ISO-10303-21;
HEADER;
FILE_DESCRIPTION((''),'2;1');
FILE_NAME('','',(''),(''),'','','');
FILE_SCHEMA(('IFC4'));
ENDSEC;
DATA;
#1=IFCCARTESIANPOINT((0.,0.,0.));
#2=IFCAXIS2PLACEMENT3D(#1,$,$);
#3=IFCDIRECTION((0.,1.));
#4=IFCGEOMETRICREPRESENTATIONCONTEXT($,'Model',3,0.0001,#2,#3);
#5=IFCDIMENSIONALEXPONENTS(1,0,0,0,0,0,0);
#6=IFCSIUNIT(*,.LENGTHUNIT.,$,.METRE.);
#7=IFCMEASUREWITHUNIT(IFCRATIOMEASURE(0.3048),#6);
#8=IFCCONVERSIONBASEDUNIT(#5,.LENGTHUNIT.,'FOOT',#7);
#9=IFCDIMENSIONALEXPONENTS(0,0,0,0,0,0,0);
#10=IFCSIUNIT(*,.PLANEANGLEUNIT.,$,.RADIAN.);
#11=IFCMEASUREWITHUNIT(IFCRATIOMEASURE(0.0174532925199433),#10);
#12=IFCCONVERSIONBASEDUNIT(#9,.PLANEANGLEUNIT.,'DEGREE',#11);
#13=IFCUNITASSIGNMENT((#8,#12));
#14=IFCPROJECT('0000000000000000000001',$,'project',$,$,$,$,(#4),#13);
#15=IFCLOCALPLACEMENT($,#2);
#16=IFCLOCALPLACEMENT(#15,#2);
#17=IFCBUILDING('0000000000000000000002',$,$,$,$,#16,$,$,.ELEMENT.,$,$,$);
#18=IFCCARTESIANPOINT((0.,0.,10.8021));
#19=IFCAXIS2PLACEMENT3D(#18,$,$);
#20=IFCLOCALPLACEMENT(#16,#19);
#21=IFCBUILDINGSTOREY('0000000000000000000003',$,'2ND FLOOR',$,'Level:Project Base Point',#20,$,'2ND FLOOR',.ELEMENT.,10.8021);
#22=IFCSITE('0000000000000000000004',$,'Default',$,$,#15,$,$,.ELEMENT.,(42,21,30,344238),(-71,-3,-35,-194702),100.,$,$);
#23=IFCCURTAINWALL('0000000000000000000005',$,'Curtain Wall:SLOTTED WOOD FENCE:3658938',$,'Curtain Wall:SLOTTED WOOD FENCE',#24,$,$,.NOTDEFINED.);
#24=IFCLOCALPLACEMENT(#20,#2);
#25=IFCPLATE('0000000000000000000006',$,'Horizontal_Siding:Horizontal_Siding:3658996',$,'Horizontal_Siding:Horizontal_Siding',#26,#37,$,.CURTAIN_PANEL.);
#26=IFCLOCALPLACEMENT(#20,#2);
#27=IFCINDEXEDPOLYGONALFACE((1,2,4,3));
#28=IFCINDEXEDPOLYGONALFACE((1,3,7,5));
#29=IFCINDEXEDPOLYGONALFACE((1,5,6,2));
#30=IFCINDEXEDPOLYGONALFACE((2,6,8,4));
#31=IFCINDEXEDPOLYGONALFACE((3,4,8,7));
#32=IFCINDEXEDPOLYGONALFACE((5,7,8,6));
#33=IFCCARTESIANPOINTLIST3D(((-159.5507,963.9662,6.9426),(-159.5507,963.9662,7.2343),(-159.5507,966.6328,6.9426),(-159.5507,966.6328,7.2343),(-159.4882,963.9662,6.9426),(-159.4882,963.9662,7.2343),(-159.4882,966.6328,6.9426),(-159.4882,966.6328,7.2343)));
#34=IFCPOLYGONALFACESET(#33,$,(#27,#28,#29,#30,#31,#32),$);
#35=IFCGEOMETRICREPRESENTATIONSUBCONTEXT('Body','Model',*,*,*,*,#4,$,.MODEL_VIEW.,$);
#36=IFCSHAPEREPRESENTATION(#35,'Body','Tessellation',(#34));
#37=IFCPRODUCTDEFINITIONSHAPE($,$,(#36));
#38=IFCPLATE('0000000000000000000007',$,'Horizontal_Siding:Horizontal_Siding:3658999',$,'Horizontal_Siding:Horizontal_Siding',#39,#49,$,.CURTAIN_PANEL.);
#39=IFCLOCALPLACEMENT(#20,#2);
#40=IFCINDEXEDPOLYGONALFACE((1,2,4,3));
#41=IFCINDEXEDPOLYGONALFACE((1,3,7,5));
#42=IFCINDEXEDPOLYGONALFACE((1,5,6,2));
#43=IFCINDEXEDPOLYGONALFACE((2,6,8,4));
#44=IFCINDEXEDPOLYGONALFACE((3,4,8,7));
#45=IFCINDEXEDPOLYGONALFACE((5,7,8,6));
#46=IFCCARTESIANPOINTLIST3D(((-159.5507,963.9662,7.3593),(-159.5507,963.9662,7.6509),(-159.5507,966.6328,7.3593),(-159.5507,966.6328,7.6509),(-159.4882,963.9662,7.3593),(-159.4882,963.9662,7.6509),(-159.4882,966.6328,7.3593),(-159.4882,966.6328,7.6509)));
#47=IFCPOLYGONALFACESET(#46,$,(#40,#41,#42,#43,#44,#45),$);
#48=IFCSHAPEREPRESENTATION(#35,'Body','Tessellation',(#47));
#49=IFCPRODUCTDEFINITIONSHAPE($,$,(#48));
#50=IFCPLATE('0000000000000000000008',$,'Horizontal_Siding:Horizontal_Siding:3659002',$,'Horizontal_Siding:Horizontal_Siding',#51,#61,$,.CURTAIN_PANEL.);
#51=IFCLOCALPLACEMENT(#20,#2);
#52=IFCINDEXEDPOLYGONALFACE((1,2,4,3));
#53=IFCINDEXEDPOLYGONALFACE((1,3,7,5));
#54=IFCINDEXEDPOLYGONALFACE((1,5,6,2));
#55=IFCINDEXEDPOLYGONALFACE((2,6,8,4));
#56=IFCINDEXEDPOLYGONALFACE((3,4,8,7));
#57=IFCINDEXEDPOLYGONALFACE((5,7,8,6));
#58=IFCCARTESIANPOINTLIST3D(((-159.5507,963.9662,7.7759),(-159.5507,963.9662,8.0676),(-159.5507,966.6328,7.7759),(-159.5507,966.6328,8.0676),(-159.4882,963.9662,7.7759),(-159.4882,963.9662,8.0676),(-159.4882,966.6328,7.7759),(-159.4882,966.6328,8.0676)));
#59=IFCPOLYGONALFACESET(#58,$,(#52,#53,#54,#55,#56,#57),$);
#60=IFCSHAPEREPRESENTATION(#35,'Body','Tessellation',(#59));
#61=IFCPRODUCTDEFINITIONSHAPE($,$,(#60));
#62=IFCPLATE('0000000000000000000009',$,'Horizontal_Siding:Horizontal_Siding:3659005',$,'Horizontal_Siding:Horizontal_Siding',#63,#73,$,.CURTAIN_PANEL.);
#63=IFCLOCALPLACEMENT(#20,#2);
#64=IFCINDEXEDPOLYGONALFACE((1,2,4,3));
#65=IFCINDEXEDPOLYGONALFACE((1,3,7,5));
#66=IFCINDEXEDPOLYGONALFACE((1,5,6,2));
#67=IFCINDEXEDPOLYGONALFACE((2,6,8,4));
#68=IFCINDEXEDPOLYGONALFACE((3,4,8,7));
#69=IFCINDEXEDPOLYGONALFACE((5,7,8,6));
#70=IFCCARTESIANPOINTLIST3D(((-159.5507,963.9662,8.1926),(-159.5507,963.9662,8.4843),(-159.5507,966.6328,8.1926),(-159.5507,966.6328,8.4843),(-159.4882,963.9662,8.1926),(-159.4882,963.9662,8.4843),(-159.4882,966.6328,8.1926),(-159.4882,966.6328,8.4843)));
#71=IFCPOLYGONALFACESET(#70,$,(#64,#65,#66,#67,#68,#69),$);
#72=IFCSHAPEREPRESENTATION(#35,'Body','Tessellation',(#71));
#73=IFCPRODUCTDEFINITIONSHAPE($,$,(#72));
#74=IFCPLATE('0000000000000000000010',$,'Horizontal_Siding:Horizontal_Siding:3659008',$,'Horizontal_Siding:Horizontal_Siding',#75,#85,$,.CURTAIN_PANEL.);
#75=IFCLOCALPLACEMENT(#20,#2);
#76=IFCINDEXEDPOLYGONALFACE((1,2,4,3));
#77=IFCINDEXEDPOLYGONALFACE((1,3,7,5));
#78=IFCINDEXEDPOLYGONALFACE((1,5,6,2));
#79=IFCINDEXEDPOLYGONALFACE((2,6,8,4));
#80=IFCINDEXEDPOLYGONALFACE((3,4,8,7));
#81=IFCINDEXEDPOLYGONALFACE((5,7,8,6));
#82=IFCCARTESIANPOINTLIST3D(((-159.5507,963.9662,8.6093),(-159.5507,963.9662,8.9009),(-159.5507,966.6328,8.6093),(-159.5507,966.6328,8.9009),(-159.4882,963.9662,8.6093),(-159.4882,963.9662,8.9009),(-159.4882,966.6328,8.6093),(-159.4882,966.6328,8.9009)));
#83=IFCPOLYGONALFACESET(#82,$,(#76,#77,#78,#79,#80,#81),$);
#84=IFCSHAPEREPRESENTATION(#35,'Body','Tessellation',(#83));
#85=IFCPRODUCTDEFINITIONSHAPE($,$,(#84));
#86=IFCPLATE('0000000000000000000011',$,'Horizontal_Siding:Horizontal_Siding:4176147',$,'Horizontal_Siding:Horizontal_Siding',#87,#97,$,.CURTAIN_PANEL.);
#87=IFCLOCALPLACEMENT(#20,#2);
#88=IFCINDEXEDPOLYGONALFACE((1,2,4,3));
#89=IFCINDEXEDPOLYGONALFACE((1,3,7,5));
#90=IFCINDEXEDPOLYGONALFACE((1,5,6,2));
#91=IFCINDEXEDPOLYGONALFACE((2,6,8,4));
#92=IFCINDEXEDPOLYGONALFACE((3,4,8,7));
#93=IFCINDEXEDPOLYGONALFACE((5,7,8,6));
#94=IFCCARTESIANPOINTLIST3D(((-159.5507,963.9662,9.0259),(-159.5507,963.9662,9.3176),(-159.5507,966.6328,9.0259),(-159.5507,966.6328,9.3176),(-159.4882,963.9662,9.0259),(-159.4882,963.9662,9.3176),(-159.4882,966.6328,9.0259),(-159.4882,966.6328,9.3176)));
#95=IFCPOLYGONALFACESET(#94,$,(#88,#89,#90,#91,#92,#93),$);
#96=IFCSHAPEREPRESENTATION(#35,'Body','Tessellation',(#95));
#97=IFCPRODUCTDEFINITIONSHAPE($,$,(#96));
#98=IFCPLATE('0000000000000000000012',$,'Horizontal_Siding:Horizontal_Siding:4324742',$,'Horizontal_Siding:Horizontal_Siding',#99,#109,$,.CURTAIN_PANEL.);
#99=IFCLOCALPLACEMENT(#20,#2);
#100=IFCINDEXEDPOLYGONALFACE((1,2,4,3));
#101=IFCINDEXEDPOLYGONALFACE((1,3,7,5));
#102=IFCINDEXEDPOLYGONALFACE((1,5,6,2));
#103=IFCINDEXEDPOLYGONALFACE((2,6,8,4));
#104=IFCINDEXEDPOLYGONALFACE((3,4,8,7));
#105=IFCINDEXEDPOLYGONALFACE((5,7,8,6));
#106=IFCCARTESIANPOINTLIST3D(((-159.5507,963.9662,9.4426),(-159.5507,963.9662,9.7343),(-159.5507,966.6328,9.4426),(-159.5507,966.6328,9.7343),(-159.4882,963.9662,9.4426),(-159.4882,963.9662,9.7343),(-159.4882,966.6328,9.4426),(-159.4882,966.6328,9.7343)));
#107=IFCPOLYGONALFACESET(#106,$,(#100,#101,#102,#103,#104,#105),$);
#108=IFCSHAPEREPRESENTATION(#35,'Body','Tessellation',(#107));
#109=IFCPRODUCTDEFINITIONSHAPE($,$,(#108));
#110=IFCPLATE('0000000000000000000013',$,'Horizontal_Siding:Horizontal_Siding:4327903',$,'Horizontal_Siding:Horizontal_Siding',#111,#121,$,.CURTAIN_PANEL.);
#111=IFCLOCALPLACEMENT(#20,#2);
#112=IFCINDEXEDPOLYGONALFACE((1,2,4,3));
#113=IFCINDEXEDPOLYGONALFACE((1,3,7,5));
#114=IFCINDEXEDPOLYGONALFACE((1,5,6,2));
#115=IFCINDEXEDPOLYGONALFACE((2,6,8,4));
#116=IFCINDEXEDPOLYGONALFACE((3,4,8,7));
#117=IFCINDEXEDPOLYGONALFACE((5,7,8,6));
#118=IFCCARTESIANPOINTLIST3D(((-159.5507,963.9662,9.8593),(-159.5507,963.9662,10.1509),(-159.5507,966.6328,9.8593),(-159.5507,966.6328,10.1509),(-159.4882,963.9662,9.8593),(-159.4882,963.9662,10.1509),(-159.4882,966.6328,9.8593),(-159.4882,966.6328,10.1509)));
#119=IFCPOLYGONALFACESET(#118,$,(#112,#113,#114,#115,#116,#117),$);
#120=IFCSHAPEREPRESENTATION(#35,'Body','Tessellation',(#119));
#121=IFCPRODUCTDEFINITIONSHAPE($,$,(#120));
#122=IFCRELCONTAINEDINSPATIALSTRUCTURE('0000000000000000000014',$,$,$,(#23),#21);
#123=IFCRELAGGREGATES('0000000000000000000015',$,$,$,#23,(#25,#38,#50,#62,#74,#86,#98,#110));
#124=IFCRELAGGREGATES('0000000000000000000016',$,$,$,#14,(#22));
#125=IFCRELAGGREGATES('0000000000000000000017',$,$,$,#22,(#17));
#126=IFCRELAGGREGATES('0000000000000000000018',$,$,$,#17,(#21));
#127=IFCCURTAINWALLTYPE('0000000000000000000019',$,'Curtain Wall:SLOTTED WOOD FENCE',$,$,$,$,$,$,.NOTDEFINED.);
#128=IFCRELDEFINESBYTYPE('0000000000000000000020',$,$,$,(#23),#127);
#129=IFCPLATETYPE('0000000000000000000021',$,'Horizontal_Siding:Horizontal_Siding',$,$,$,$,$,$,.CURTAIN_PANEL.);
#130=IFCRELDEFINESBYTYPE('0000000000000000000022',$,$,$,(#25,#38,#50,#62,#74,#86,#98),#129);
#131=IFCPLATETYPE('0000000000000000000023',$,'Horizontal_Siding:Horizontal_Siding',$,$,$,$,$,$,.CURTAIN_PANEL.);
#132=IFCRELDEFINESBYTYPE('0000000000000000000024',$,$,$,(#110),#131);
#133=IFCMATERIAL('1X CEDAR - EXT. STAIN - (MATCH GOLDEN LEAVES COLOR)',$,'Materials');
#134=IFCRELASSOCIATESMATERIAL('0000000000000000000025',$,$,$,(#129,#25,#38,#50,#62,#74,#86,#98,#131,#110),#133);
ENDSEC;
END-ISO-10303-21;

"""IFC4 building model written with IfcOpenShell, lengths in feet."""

from ifc_helpers import new_model, entity, si_unit, converted_unit, direction, frame, origin, origin_2d_with_axis, place, context, subcontext, project, spatial, rectangle, extrude, source, transform, mapped, material, type_object, type_shapes, element, aggregate, save


model = new_model("IFC4")

# Units and contexts
model_context = context("Model", 3, precision=0.0001, world=origin(), true_north=direction((0.0, 1.0)))
body_context = subcontext(model_context, "Body", "Model", "MODEL_VIEW")
ifc_project = project(units=[converted_unit("LENGTHUNIT", "FOOT", entity("IfcRatioMeasure", 0.3048), si_unit("LENGTHUNIT", "METRE"), dimensions=[1, 0, 0, 0, 0, 0, 0]), converted_unit("PLANEANGLEUNIT", "DEGREE", entity("IfcRatioMeasure", 0.0174532925199433), si_unit("PLANEANGLEUNIT", "RADIAN"), dimensions=[0, 0, 0, 0, 0, 0, 0])], contexts=[model_context])

# Site, building, storey
site_placement = place(None, origin())
site = spatial("IfcSite", under=ifc_project, at=site_placement, Name="Default", CompositionType="ELEMENT", RefLatitude=(42, 21, 30, 344238), RefLongitude=(-71, -3, -35, -194702), RefElevation=100.0)
building_placement = place(site_placement, origin())
building = spatial("IfcBuilding", under=site, at=building_placement, CompositionType="ELEMENT")
storey_placement = place(building_placement, frame((0.0, 0.0, 10.8021)))
storey = spatial("IfcBuildingStorey", under=building, at=storey_placement, Name="2ND FLOOR", ObjectType="Level:Project Base Point", LongName="2ND FLOOR", CompositionType="ELEMENT", Elevation=10.8021)

# Curtain wall
curtain_wall_type_1 = type_object("IfcCurtainWallType", Name="Curtain Wall:SLOTTED WOOD FENCE", PredefinedType="NOTDEFINED")
curtain_wall_1_placement = place(storey_placement, frame((0.0, 0.0, -10.8021)))
curtain_wall_1 = element("IfcCurtainWall", 1, at=curtain_wall_1_placement, inside=storey, type_object=curtain_wall_type_1, Name="Curtain Wall:SLOTTED WOOD FENCE:3658938", ObjectType="Curtain Wall:SLOTTED WOOD FENCE", PredefinedType="NOTDEFINED")

# Plates
ifc_material_1 = material(Name="1X CEDAR - EXT. STAIN - (MATCH GOLDEN LEAVES COLOR)", Category="Materials")
plate_type_1 = type_object("IfcPlateType", Name="Horizontal_Siding:Horizontal_Siding", PredefinedType="CURTAIN_PANEL", material=ifc_material_1)
shared_shape_1 = source(origin(), body_context, "Body", "SweptSolid", [
    extrude(rectangle(XDim=2.6667, YDim=0.0625, at=origin_2d_with_axis()), frame((1.3333, 0.0312, 0.0), z_axis=(0.0, 0.0, 1.0), x_axis=(-1.0, 0.0, 0.0)), (0.0, 0.0, 1.0), 0.2917),
])
type_shapes(plate_type_1, [shared_shape_1])
plate_1_placement = place(curtain_wall_1_placement, frame((-159.5507, 966.6328, 17.7447), z_axis=(0.0, 0.0, 1.0), x_axis=(0.0, -1.0, 0.0)))
plate_1 = element("IfcPlate", 2, at=plate_1_placement, type_object=plate_type_1, material=ifc_material_1, Name="Horizontal_Siding:Horizontal_Siding:3658996", ObjectType="Horizontal_Siding:Horizontal_Siding", PredefinedType="CURTAIN_PANEL", context=body_context, shape_type="MappedRepresentation", body=[
    mapped(shared_shape_1, transform((0.0, 0.0, 0.0), scale=1.0)),
])
plate_2_placement = place(curtain_wall_1_placement, frame((-159.5507, 966.6328, 18.1613), z_axis=(0.0, 0.0, 1.0), x_axis=(0.0, -1.0, 0.0)))
plate_2 = element("IfcPlate", 3, at=plate_2_placement, type_object=plate_type_1, material=ifc_material_1, Name="Horizontal_Siding:Horizontal_Siding:3658999", ObjectType="Horizontal_Siding:Horizontal_Siding", PredefinedType="CURTAIN_PANEL", context=body_context, shape_type="MappedRepresentation", body=[
    mapped(shared_shape_1, transform((0.0, 0.0, 0.0), scale=1.0)),
])
plate_3_placement = place(curtain_wall_1_placement, frame((-159.5507, 966.6328, 18.578), z_axis=(0.0, 0.0, 1.0), x_axis=(0.0, -1.0, 0.0)))
plate_3 = element("IfcPlate", 4, at=plate_3_placement, type_object=plate_type_1, material=ifc_material_1, Name="Horizontal_Siding:Horizontal_Siding:3659002", ObjectType="Horizontal_Siding:Horizontal_Siding", PredefinedType="CURTAIN_PANEL", context=body_context, shape_type="MappedRepresentation", body=[
    mapped(shared_shape_1, transform((0.0, 0.0, 0.0), scale=1.0)),
])
plate_4_placement = place(curtain_wall_1_placement, frame((-159.5507, 966.6328, 18.9947), z_axis=(0.0, 0.0, 1.0), x_axis=(0.0, -1.0, 0.0)))
plate_4 = element("IfcPlate", 5, at=plate_4_placement, type_object=plate_type_1, material=ifc_material_1, Name="Horizontal_Siding:Horizontal_Siding:3659005", ObjectType="Horizontal_Siding:Horizontal_Siding", PredefinedType="CURTAIN_PANEL", context=body_context, shape_type="MappedRepresentation", body=[
    mapped(shared_shape_1, transform((0.0, 0.0, 0.0), scale=1.0)),
])
plate_5_placement = place(curtain_wall_1_placement, frame((-159.5507, 966.6328, 19.4113), z_axis=(0.0, 0.0, 1.0), x_axis=(0.0, -1.0, 0.0)))
plate_5 = element("IfcPlate", 6, at=plate_5_placement, type_object=plate_type_1, material=ifc_material_1, Name="Horizontal_Siding:Horizontal_Siding:3659008", ObjectType="Horizontal_Siding:Horizontal_Siding", PredefinedType="CURTAIN_PANEL", context=body_context, shape_type="MappedRepresentation", body=[
    mapped(shared_shape_1, transform((0.0, 0.0, 0.0), scale=1.0)),
])
plate_6_placement = place(curtain_wall_1_placement, frame((-159.5507, 966.6328, 19.828), z_axis=(0.0, 0.0, 1.0), x_axis=(0.0, -1.0, 0.0)))
plate_6 = element("IfcPlate", 7, at=plate_6_placement, type_object=plate_type_1, material=ifc_material_1, Name="Horizontal_Siding:Horizontal_Siding:4176147", ObjectType="Horizontal_Siding:Horizontal_Siding", PredefinedType="CURTAIN_PANEL", context=body_context, shape_type="MappedRepresentation", body=[
    mapped(shared_shape_1, transform((0.0, 0.0, 0.0), scale=1.0)),
])
plate_7_placement = place(curtain_wall_1_placement, frame((-159.5507, 966.6328, 20.2447), z_axis=(0.0, 0.0, 1.0), x_axis=(0.0, -1.0, 0.0)))
plate_7 = element("IfcPlate", 8, at=plate_7_placement, type_object=plate_type_1, material=ifc_material_1, Name="Horizontal_Siding:Horizontal_Siding:4324742", ObjectType="Horizontal_Siding:Horizontal_Siding", PredefinedType="CURTAIN_PANEL", context=body_context, shape_type="MappedRepresentation", body=[
    mapped(shared_shape_1, transform((0.0, 0.0, 0.0), scale=1.0)),
])
plate_type_2 = type_object("IfcPlateType", Name="Horizontal_Siding:Horizontal_Siding", PredefinedType="CURTAIN_PANEL", material=ifc_material_1)
shared_shape_2 = source(origin(), body_context, "Body", "SweptSolid", [
    extrude(rectangle(XDim=2.6667, YDim=0.0625, at=origin_2d_with_axis()), frame((1.3333, 0.0312, 0.0), z_axis=(0.0, 0.0, 1.0), x_axis=(-1.0, 0.0, 0.0)), (0.0, 0.0, 1.0), 0.2917),
])
type_shapes(plate_type_2, [shared_shape_2])
plate_8_placement = place(curtain_wall_1_placement, frame((-159.5507, 966.6328, 20.6613), z_axis=(0.0, 0.0, 1.0), x_axis=(0.0, -1.0, 0.0)))
plate_8 = element("IfcPlate", 9, at=plate_8_placement, type_object=plate_type_2, material=ifc_material_1, Name="Horizontal_Siding:Horizontal_Siding:4327903", ObjectType="Horizontal_Siding:Horizontal_Siding", PredefinedType="CURTAIN_PANEL", context=body_context, shape_type="MappedRepresentation", body=[
    mapped(shared_shape_2, transform((0.0, 0.0, 0.0), scale=1.0)),
])
aggregate(curtain_wall_1, [plate_1, plate_2, plate_3, plate_4, plate_5, plate_6, plate_7, plate_8])

save(model, "model.ifc")
